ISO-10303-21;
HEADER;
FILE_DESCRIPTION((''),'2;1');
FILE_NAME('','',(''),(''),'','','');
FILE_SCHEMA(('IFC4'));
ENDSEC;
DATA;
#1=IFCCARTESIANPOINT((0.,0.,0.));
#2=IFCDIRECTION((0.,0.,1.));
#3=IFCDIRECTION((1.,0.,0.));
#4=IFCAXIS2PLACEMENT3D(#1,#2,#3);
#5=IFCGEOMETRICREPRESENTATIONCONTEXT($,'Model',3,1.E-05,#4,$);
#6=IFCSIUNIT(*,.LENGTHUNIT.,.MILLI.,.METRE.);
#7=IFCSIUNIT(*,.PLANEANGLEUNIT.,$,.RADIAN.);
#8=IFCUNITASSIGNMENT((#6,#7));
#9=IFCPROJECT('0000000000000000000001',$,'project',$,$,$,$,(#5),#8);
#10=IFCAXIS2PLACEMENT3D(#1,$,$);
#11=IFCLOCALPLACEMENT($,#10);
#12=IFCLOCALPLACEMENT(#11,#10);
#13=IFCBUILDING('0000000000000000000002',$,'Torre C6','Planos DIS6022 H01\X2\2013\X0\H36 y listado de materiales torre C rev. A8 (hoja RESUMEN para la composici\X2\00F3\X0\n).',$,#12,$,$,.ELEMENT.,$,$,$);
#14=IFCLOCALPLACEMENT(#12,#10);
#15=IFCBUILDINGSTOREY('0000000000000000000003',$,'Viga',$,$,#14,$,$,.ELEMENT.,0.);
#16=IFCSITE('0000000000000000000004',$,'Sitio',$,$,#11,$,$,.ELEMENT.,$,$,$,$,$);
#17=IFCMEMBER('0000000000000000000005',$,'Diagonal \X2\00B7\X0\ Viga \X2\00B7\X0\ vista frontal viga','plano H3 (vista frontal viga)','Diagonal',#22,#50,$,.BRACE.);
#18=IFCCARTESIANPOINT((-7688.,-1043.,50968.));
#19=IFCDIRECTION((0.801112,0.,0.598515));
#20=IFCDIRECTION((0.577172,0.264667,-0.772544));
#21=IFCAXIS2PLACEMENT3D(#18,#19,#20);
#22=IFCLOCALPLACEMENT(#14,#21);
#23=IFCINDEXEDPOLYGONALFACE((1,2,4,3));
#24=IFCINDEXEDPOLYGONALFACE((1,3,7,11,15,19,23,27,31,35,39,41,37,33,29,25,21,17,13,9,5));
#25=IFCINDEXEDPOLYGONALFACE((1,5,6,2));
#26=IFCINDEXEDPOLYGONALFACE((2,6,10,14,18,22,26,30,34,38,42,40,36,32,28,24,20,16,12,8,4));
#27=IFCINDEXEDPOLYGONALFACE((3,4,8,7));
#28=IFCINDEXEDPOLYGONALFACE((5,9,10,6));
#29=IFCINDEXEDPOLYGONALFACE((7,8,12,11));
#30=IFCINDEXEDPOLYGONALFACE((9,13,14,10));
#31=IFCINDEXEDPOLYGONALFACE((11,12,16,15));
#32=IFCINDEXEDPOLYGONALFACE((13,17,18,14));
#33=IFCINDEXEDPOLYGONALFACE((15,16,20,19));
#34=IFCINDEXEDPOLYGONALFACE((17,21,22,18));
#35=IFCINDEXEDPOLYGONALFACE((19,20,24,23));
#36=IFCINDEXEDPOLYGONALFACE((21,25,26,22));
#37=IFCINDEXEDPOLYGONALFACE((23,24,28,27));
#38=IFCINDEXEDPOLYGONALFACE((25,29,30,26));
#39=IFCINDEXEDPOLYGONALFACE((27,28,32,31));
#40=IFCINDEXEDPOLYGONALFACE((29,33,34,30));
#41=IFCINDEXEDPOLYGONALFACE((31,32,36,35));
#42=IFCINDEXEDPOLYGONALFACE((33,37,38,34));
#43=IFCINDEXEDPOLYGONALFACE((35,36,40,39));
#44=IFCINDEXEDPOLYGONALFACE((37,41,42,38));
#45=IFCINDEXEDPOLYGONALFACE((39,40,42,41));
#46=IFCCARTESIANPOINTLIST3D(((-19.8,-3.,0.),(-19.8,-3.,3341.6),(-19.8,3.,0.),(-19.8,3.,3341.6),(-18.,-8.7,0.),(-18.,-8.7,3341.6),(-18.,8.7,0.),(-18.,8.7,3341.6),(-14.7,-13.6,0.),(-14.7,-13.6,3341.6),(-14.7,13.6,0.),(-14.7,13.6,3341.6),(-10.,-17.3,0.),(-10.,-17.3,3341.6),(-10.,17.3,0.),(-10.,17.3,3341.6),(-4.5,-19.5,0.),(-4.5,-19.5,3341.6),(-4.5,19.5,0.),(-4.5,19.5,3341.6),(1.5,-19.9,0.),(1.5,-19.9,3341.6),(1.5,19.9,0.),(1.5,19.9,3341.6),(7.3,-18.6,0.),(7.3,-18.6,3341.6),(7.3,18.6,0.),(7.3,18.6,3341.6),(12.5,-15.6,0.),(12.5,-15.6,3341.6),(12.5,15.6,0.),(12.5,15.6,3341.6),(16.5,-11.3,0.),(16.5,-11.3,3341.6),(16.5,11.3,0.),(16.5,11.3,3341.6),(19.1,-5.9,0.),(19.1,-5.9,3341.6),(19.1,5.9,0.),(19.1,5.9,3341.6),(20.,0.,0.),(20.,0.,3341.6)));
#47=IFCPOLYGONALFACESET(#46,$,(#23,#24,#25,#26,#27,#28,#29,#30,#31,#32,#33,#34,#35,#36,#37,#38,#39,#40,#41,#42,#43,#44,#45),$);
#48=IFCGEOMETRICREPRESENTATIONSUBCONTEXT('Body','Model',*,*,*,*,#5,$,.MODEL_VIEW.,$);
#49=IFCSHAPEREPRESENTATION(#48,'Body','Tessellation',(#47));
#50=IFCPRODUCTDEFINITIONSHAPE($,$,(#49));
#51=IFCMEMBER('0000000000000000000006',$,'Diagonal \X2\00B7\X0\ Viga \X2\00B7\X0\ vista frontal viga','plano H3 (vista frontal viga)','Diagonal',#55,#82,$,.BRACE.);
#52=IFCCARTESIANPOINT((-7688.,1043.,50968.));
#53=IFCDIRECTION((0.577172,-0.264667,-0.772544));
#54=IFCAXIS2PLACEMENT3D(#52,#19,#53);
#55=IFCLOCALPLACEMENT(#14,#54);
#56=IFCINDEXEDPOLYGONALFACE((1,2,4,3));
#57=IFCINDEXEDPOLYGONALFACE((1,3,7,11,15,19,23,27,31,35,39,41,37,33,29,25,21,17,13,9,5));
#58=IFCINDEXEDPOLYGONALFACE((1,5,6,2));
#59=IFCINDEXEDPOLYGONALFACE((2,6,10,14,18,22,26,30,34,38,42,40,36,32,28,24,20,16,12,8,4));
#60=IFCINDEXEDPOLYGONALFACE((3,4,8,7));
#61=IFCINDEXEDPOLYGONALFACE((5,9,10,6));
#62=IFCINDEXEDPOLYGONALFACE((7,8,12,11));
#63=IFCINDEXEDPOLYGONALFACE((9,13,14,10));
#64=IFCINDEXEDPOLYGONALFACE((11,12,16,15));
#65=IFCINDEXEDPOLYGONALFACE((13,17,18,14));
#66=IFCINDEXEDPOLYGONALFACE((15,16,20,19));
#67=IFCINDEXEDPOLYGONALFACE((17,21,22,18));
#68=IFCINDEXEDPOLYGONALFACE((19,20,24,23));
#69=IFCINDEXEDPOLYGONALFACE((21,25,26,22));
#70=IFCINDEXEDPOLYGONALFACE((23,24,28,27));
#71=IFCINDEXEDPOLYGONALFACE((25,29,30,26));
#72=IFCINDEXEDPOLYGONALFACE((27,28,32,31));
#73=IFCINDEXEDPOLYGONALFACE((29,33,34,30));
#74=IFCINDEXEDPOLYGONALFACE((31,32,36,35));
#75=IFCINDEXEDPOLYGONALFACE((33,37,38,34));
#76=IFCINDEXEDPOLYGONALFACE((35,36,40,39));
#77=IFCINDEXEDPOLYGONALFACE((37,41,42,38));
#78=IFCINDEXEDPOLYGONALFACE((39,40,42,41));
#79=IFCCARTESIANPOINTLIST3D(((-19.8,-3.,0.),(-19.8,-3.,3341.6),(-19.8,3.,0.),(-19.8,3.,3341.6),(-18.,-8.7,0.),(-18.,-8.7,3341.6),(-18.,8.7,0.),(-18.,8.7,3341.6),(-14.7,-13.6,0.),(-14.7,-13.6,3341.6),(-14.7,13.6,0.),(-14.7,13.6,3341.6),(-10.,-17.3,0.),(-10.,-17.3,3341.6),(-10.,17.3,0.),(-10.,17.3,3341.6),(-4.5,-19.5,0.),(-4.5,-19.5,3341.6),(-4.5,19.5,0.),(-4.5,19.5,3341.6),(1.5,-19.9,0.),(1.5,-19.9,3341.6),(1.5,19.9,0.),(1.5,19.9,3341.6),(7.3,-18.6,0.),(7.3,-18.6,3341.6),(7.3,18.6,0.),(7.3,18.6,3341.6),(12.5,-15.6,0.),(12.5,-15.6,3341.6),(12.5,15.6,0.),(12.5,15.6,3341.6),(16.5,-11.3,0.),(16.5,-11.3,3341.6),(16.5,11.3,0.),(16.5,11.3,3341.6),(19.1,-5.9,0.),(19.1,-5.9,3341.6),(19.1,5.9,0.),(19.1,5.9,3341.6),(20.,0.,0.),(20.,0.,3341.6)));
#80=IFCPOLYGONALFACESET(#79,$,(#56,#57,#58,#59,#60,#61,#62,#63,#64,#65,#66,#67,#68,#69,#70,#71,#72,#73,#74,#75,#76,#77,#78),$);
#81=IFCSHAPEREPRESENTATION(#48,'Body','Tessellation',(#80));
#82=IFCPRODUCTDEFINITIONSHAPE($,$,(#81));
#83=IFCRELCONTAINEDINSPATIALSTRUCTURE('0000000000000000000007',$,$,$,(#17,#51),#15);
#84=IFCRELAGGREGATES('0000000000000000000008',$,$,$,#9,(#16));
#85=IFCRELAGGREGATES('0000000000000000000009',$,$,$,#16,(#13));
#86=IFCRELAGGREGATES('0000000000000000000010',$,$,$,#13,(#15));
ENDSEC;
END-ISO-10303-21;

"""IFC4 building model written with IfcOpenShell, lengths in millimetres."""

from ifc_helpers import new_model, si_unit, frame, origin, origin_with_axes, place, context, subcontext, project, spatial, circle, extrude, element, save


model = new_model("IFC4")

# Units and contexts
model_context = context("Model", 3, precision=1e-05, world=origin_with_axes())
body_context = subcontext(model_context, "Body", "Model", "MODEL_VIEW")
ifc_project = project(units=[si_unit("LENGTHUNIT", "METRE", prefix="MILLI"), si_unit("PLANEANGLEUNIT", "RADIAN")], contexts=[model_context])

# Site, building, storey
site_placement = place(None, origin())
site = spatial("IfcSite", under=ifc_project, at=site_placement, Name="Sitio", CompositionType="ELEMENT")
building_placement = place(site_placement, origin())
building = spatial("IfcBuilding", under=site, at=building_placement, Name="Torre C6", Description="Planos DIS6022 H01–H36 y listado de materiales torre C rev. A8 (hoja RESUMEN para la composición).", CompositionType="ELEMENT")
storey_placement = place(building_placement, origin())
storey = spatial("IfcBuildingStorey", under=building, at=storey_placement, Name="Viga", CompositionType="ELEMENT", Elevation=0.0)

# Members
for number, where, z_axis, x_axis, name in (
    (1, (-7688.0, -1043.0, 50968.0), (0.801112, 0.0, 0.598515), (0.577172, 0.264667, -0.772544), "Diagonal · Viga · vista frontal viga"),
    (2, (-7688.0, 1043.0, 50968.0), (0.801112, 0.0, 0.598515), (0.577172, -0.264667, -0.772544), "Diagonal · Viga · vista frontal viga"),
):
    element("IfcMember", number, at=place(storey_placement, frame(where, z_axis=z_axis, x_axis=x_axis)), inside=storey, Name=name, Description="plano H3 (vista frontal viga)", ObjectType="Diagonal", PredefinedType="BRACE", context=body_context, shape_type="SweptSolid", body=[
        extrude(circle(Radius=20.0), None, (0.0, 0.0, 1.0), 3341.6),
    ])

save(model, "model.ifc")
